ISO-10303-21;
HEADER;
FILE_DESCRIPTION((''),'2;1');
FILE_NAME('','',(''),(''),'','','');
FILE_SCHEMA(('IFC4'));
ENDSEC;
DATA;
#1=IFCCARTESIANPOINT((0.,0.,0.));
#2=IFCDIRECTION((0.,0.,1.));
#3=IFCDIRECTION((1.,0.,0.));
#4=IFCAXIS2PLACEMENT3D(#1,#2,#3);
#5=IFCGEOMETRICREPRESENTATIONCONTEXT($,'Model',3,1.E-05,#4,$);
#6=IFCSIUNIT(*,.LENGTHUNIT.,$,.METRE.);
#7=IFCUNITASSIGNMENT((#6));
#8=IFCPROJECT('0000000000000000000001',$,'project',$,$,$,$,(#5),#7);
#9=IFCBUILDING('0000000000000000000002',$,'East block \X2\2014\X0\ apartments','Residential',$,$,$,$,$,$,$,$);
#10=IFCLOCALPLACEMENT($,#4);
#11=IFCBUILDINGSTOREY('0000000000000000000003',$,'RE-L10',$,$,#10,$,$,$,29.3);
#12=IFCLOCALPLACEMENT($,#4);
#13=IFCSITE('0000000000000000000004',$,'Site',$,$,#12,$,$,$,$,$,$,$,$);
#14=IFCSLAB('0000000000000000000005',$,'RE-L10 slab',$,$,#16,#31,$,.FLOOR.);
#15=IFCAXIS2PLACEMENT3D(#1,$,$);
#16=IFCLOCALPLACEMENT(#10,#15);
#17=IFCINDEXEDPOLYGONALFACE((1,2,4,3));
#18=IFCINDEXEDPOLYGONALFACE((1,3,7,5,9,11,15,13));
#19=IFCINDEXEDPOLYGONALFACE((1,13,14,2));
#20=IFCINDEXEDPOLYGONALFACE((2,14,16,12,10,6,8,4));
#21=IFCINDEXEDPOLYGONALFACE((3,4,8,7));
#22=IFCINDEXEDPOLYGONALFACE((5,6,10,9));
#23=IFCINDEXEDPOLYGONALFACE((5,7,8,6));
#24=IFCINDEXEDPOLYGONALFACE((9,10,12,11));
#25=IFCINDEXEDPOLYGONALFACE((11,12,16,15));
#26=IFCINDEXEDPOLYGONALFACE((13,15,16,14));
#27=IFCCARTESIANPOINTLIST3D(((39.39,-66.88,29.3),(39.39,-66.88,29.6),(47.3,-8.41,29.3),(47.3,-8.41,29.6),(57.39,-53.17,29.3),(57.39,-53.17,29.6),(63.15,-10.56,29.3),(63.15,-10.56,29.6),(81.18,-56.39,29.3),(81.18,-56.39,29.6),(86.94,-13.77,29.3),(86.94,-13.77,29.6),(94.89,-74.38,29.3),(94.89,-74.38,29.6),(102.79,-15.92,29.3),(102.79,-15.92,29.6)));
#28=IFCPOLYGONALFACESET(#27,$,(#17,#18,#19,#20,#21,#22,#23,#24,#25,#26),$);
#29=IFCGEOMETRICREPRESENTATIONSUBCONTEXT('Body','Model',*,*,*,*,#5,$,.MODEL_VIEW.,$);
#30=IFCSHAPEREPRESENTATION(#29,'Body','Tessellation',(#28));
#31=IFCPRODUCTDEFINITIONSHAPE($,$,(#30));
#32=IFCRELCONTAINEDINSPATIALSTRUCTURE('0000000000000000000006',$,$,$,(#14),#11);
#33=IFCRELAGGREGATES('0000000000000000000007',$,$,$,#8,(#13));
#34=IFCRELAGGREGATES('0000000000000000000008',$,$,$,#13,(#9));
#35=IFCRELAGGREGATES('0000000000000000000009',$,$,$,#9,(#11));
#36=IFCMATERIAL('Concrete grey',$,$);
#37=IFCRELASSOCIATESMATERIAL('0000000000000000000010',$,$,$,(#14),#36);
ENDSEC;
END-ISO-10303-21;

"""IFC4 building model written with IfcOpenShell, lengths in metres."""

from ifc_helpers import new_model, si_unit, frame, origin_with_axes, place, context, subcontext, project, spatial, polyline, outline, extrude, material, element, save


model = new_model("IFC4")

# Units and contexts
model_context = context("Model", 3, precision=1e-05, world=origin_with_axes())
body_context = subcontext(model_context, "Body", "Model", "MODEL_VIEW")
ifc_project = project(units=[si_unit("LENGTHUNIT", "METRE")], contexts=[model_context])

# Site, building, storey
site_placement = place(None, origin_with_axes())
site = spatial("IfcSite", under=ifc_project, at=site_placement, Name="Site")
building = spatial("IfcBuilding", under=site, Name="East block — apartments", Description="Residential")
storey_placement = place(None, origin_with_axes())
storey = spatial("IfcBuildingStorey", under=building, at=storey_placement, Name="RE-L10", Elevation=29.3)

# Slab
ifc_material = material(Name="Concrete grey")
slab_placement = place(storey_placement, origin_with_axes())
element("IfcSlab", 1, at=slab_placement, inside=storey, material=ifc_material, Name="RE-L10 slab", PredefinedType="FLOOR", context=body_context, shape_type="SweptSolid", body=[
    extrude(outline(polyline([(39.39, -66.88), (94.89, -74.38), (102.79, -15.92), (86.94, -13.77), (81.18, -56.39), (57.39, -53.17), (63.15, -10.56), (47.3, -8.41), (39.39, -66.88)])), frame((0.0, 0.0, 29.3), z_axis=(0.0, 0.0, 1.0), x_axis=(1.0, 0.0, 0.0)), (0.0, 0.0, 1.0), 0.3),
])

save(model, "model.ifc")
